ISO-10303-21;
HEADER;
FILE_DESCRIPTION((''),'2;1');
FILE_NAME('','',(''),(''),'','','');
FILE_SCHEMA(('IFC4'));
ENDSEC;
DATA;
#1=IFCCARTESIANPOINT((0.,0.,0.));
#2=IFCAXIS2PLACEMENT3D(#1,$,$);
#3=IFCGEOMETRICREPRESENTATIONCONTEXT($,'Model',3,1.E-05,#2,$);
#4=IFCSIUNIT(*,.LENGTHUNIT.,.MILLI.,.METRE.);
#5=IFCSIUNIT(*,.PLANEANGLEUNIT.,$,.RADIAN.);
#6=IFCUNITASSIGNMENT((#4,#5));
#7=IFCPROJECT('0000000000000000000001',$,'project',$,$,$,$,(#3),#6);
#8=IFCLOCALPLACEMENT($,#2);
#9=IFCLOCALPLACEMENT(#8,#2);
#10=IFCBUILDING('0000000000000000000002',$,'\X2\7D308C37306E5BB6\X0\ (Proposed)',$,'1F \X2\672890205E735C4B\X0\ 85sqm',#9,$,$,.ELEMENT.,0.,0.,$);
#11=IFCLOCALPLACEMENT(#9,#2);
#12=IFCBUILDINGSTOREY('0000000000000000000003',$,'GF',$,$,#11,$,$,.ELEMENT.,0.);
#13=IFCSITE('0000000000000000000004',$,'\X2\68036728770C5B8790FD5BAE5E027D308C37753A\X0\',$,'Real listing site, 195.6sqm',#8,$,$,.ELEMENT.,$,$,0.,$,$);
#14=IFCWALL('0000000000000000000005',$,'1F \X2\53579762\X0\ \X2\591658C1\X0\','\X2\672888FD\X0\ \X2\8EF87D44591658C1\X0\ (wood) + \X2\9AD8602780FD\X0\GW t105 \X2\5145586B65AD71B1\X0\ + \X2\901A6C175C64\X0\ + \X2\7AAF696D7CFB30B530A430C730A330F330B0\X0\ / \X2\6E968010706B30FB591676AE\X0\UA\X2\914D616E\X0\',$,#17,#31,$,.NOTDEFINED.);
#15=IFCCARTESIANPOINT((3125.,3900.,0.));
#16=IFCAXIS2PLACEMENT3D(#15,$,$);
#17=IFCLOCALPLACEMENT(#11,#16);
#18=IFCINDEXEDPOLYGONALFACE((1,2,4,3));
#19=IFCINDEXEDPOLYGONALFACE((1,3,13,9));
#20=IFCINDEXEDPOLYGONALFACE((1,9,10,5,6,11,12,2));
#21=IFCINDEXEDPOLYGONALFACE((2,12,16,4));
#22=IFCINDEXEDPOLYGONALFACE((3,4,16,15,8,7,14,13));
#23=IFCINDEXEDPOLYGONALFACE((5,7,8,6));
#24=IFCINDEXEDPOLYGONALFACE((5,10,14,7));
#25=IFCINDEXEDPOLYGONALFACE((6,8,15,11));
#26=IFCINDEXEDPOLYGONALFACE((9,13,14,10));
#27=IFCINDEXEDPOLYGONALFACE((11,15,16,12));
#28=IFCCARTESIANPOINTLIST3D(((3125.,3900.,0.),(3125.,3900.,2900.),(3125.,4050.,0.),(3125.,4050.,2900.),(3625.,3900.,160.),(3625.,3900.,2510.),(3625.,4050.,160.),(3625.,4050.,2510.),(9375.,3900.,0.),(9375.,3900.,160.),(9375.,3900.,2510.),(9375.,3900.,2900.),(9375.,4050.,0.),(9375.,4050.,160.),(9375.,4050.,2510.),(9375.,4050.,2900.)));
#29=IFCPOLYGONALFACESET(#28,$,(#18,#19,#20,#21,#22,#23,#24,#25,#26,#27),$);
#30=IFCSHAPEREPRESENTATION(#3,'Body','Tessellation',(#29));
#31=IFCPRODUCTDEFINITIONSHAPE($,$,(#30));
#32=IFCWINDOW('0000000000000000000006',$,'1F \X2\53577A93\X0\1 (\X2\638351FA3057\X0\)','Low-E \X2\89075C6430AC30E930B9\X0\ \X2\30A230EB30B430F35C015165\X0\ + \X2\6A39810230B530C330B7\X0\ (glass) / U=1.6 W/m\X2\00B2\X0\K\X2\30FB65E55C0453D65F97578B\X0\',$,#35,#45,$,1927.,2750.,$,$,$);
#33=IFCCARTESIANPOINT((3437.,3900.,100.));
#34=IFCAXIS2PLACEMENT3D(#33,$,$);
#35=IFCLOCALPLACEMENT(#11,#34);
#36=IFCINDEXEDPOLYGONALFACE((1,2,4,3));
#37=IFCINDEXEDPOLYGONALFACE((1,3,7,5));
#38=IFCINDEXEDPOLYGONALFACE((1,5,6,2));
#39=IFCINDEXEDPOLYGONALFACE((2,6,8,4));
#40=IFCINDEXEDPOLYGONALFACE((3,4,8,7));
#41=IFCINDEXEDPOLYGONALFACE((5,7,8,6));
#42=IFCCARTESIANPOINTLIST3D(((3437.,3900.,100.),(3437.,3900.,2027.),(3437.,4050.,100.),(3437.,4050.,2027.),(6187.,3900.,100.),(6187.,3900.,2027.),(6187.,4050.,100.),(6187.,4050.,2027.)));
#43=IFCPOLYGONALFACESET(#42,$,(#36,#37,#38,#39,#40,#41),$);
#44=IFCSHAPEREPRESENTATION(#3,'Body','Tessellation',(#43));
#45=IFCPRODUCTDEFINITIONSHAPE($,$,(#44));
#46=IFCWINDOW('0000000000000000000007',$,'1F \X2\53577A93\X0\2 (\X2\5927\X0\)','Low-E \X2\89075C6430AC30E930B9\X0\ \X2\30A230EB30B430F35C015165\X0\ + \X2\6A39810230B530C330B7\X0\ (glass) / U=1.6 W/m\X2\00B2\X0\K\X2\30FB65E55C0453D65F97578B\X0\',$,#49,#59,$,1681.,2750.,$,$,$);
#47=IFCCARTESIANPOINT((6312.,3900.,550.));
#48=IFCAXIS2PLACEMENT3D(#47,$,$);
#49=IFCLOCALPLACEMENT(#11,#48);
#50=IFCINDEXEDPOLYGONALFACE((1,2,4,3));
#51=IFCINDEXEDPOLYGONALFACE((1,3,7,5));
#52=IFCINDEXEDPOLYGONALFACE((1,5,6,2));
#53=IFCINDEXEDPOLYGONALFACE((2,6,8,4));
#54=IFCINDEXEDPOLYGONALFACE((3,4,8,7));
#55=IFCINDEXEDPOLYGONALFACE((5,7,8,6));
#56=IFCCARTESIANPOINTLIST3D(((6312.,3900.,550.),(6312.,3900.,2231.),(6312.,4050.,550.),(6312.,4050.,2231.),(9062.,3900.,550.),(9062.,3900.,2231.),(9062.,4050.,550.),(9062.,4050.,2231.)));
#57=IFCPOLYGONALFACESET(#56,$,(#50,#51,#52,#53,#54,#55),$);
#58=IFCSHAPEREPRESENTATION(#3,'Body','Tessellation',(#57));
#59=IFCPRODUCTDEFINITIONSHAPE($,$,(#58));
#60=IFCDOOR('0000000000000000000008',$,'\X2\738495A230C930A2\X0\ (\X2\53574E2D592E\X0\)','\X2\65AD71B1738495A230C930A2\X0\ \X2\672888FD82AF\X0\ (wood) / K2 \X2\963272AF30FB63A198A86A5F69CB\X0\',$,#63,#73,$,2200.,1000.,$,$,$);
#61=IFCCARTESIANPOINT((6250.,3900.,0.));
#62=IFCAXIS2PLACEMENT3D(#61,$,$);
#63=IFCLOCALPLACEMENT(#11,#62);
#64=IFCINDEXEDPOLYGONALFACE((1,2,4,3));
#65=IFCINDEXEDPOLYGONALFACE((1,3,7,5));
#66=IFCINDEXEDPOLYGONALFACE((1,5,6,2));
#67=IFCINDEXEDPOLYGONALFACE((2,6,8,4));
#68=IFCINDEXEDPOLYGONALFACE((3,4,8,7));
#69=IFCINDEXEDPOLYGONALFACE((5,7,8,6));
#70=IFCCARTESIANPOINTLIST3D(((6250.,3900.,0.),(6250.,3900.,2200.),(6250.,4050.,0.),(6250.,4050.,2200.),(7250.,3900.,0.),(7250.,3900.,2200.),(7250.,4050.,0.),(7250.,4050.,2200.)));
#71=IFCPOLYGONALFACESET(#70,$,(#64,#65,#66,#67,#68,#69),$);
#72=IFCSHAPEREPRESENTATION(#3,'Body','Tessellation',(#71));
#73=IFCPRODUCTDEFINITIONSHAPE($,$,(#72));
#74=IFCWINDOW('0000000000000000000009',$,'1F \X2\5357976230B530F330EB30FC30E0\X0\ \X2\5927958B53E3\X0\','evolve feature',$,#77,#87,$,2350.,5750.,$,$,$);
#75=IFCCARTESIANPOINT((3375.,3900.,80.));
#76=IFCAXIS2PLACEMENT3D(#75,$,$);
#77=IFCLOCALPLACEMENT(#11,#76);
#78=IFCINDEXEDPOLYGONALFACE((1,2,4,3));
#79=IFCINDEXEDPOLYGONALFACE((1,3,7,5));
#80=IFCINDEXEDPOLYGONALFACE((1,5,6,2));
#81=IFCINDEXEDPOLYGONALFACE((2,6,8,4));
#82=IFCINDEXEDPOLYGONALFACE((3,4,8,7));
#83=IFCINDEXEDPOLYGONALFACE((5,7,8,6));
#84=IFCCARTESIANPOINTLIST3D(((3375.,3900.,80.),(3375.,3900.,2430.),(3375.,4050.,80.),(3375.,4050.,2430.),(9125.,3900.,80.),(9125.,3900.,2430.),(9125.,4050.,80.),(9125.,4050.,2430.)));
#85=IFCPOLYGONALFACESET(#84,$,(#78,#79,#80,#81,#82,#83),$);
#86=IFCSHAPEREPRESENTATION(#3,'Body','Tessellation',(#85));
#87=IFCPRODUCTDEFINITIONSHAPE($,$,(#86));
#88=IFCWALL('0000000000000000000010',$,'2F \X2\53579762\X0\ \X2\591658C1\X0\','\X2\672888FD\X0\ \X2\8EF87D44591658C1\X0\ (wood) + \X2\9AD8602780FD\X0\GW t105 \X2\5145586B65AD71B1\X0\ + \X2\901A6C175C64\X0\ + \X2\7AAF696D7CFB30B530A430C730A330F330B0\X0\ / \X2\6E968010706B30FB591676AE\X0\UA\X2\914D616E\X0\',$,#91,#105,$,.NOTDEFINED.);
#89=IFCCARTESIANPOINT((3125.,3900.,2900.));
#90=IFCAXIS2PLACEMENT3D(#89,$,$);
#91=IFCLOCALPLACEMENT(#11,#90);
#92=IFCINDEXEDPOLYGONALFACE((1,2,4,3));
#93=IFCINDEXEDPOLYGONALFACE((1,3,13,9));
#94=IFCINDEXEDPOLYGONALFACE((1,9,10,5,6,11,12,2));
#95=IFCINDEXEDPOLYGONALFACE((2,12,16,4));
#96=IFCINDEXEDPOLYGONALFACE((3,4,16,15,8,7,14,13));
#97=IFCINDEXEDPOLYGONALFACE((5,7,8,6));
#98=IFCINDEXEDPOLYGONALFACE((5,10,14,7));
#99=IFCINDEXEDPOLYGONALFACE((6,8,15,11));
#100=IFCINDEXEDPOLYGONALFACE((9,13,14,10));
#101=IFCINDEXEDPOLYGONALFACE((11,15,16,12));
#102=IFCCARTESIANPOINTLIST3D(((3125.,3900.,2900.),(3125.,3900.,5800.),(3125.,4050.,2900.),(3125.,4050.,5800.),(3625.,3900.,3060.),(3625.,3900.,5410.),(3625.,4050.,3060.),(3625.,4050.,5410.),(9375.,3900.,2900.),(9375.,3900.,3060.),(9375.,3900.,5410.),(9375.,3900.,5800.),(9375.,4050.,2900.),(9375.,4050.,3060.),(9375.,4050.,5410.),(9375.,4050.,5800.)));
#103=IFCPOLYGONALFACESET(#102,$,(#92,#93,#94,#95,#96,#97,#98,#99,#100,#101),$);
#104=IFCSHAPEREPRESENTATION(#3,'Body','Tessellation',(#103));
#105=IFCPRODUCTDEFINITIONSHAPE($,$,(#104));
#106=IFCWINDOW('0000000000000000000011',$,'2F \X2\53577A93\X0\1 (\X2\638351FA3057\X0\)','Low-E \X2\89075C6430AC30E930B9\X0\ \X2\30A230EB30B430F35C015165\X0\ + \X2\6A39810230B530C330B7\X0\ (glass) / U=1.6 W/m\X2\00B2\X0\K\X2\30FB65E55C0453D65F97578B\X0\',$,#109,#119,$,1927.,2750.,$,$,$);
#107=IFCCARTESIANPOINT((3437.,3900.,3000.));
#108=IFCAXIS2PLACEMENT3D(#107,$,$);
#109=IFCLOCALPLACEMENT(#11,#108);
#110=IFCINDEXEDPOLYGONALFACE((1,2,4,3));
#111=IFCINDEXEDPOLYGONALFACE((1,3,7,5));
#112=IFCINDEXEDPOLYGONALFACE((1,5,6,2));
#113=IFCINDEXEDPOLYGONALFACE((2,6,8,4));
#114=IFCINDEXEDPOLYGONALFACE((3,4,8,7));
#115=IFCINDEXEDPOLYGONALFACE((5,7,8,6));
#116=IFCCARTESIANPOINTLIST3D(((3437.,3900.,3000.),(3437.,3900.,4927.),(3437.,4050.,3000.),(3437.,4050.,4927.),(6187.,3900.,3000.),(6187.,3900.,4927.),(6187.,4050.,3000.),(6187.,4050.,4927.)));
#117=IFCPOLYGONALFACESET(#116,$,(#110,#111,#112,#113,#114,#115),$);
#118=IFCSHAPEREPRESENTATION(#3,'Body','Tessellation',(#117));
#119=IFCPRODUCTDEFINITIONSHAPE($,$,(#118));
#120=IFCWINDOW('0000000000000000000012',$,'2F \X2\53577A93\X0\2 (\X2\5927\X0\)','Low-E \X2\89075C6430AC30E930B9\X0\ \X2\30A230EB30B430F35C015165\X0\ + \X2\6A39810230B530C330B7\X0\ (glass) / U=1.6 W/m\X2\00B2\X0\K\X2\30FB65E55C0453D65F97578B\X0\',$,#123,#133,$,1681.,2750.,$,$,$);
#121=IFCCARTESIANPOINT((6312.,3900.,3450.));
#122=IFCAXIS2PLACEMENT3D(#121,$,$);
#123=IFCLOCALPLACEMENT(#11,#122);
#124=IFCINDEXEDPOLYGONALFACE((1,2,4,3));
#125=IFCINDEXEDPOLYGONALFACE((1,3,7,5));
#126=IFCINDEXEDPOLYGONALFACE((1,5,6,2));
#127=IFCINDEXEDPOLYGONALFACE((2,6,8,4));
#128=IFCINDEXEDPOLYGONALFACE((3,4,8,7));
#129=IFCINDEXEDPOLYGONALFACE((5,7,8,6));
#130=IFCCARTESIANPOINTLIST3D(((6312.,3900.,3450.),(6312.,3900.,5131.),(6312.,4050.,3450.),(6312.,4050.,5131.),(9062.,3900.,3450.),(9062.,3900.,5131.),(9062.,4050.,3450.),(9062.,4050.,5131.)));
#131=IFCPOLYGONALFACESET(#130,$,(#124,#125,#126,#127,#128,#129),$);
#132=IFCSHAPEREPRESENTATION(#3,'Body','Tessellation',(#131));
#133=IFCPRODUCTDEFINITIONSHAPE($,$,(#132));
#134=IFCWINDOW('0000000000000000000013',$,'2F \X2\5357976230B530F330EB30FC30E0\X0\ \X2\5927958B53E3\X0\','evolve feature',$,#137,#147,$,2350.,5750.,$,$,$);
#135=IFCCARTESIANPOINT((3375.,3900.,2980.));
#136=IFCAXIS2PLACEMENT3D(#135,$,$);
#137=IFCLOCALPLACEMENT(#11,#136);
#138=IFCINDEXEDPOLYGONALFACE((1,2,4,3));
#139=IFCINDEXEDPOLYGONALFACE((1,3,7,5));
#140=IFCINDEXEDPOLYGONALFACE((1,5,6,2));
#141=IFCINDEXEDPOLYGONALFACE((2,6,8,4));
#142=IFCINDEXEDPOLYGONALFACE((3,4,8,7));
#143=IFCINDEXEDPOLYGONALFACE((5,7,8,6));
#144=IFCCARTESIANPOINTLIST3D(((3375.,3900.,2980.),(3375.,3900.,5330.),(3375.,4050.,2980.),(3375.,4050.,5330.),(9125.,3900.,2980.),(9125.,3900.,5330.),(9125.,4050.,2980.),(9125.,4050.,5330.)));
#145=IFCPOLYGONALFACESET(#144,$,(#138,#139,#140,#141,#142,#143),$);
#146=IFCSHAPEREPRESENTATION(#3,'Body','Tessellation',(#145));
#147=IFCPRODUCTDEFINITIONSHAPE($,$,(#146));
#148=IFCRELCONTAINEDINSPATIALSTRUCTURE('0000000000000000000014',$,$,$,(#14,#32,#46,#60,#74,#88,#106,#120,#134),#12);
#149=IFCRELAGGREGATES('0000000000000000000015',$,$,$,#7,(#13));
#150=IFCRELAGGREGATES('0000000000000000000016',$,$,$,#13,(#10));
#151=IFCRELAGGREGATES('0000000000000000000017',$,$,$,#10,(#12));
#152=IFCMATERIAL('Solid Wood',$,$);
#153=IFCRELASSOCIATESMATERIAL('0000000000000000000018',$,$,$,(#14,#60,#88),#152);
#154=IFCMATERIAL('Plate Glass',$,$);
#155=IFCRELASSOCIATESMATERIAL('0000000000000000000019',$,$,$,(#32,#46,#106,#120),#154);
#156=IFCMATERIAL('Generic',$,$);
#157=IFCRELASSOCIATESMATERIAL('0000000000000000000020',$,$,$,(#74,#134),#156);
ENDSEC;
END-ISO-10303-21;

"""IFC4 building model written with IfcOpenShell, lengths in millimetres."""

from ifc_helpers import new_model, si_unit, frame, frame_2d, origin, place, context, project, spatial, rectangle, extrude, material, element, fill, save


model = new_model("IFC4")

# Units and contexts
model_context = context("Model", 3, precision=1e-05, world=origin())
ifc_project = project(units=[si_unit("LENGTHUNIT", "METRE", prefix="MILLI"), si_unit("PLANEANGLEUNIT", "RADIAN")], contexts=[model_context])

# Site, building, storey
site_placement = place(None, origin())
site = spatial("IfcSite", under=ifc_project, at=site_placement, Name="栃木県宇都宮市細谷町", ObjectType="Real listing site, 195.6sqm", CompositionType="ELEMENT", RefElevation=0.0)
building_placement = place(site_placement, origin())
building = spatial("IfcBuilding", under=site, at=building_placement, Name="細谷の家 (Proposed)", ObjectType="1F 木造平屋 85sqm", CompositionType="ELEMENT", ElevationOfRefHeight=0.0, ElevationOfTerrain=0.0)
storey_placement = place(building_placement, origin())
storey = spatial("IfcBuildingStorey", under=building, at=storey_placement, Name="GF", CompositionType="ELEMENT", Elevation=0.0)

# Shared definitions
ifc_material_1 = material(Name="Solid Wood")
ifc_material_2 = material(Name="Generic")

# Wall, openings, windows, door
wall_1_placement = place(storey_placement, frame((3125.0, 3900.0, 0.0)))
wall_1 = element("IfcWall", 1, at=wall_1_placement, inside=storey, material=ifc_material_1, Name="1F 南面 外壁", Description="木製 軸組外壁 (wood) + 高性能GW t105 充填断熱 + 通気層 + 窯業系サイディング / 準耐火・外皮UA配慮", PredefinedType="NOTDEFINED", context=model_context, shape_type="SweptSolid", body=[
    extrude(rectangle(XDim=6250.0, YDim=150.0, at=frame_2d((3125.0, 75.0))), frame((3125.0, 3900.0, 0.0)), (0.0, 0.0, 1.0), 2900.0),
])
opening_1_placement = place(storey_placement, frame((3437.0, 3900.0, 100.0)))
opening_1 = element("IfcOpeningElement", 2, at=opening_1_placement, cuts=wall_1, PredefinedType="NOTDEFINED", context=model_context, shape_type="SweptSolid", body=[
    extrude(rectangle(XDim=2750.0, YDim=150.0, at=frame_2d((1375.0, 75.0))), frame((3437.0, 3900.0, 100.0)), (0.0, 0.0, 1.0), 1927.0),
])
opening_2_placement = place(storey_placement, frame((6312.0, 3900.0, 550.0)))
opening_2 = element("IfcOpeningElement", 3, at=opening_2_placement, cuts=wall_1, PredefinedType="NOTDEFINED", context=model_context, shape_type="SweptSolid", body=[
    extrude(rectangle(XDim=2750.0, YDim=150.0, at=frame_2d((1375.0, 75.0))), frame((6312.0, 3900.0, 550.0)), (0.0, 0.0, 1.0), 1681.0),
])
opening_3_placement = place(storey_placement, frame((6250.0, 3900.0, 0.0)))
opening_3 = element("IfcOpeningElement", 4, at=opening_3_placement, cuts=wall_1, PredefinedType="NOTDEFINED", context=model_context, shape_type="SweptSolid", body=[
    extrude(rectangle(XDim=1000.0, YDim=150.0, at=frame_2d((500.0, 75.0))), frame((6250.0, 3900.0, 0.0)), (0.0, 0.0, 1.0), 2200.0),
])
opening_4_placement = place(storey_placement, frame((3375.0, 3900.0, 80.0)))
opening_4 = element("IfcOpeningElement", 5, at=opening_4_placement, cuts=wall_1, PredefinedType="NOTDEFINED", context=model_context, shape_type="SweptSolid", body=[
    extrude(rectangle(XDim=5750.0, YDim=150.0, at=frame_2d((2875.0, 75.0))), frame((3375.0, 3900.0, 80.0)), (0.0, 0.0, 1.0), 2350.0),
])
ifc_material_3 = material(Name="Plate Glass")
window_1_placement = place(storey_placement, frame((3437.0, 3900.0, 100.0)))
window_1 = element("IfcWindow", 6, at=window_1_placement, inside=storey, material=ifc_material_3, Name="1F 南窓1 (掃出し)", Description="Low-E 複層ガラス アルゴン封入 + 樹脂サッシ (glass) / U=1.6 W/m²K・日射取得型", OverallHeight=1927.0, OverallWidth=2750.0, context=model_context, shape_type="SweptSolid", body=[
    extrude(rectangle(XDim=2750.0, YDim=150.0, at=frame_2d((1375.0, 75.0))), frame((3437.0, 3900.0, 100.0)), (0.0, 0.0, 1.0), 1927.0),
])
fill(opening_1, window_1)
window_2_placement = place(storey_placement, frame((6312.0, 3900.0, 550.0)))
window_2 = element("IfcWindow", 7, at=window_2_placement, inside=storey, material=ifc_material_3, Name="1F 南窓2 (大)", Description="Low-E 複層ガラス アルゴン封入 + 樹脂サッシ (glass) / U=1.6 W/m²K・日射取得型", OverallHeight=1681.0, OverallWidth=2750.0, context=model_context, shape_type="SweptSolid", body=[
    extrude(rectangle(XDim=2750.0, YDim=150.0, at=frame_2d((1375.0, 75.0))), frame((6312.0, 3900.0, 550.0)), (0.0, 0.0, 1.0), 1681.0),
])
fill(opening_2, window_2)
door_placement = place(storey_placement, frame((6250.0, 3900.0, 0.0)))
door = element("IfcDoor", 8, at=door_placement, inside=storey, material=ifc_material_1, Name="玄関ドア (南中央)", Description="断熱玄関ドア 木製芯 (wood) / K2 防犯・採風機構", OverallHeight=2200.0, OverallWidth=1000.0, context=model_context, shape_type="SweptSolid", body=[
    extrude(rectangle(XDim=1000.0, YDim=150.0, at=frame_2d((500.0, 75.0))), frame((6250.0, 3900.0, 0.0)), (0.0, 0.0, 1.0), 2200.0),
])
fill(opening_3, door)
window_3_placement = place(storey_placement, frame((3375.0, 3900.0, 80.0)))
window_3 = element("IfcWindow", 9, at=window_3_placement, inside=storey, material=ifc_material_2, Name="1F 南面サンルーム 大開口", Description="evolve feature", OverallHeight=2350.0, OverallWidth=5750.0, context=model_context, shape_type="SweptSolid", body=[
    extrude(rectangle(XDim=5750.0, YDim=150.0, at=frame_2d((2875.0, 75.0))), frame((3375.0, 3900.0, 80.0)), (0.0, 0.0, 1.0), 2350.0),
])
fill(opening_4, window_3)

# Wall, openings, windows
wall_2_placement = place(storey_placement, frame((3125.0, 3900.0, 2900.0)))
wall_2 = element("IfcWall", 10, at=wall_2_placement, inside=storey, material=ifc_material_1, Name="2F 南面 外壁", Description="木製 軸組外壁 (wood) + 高性能GW t105 充填断熱 + 通気層 + 窯業系サイディング / 準耐火・外皮UA配慮", PredefinedType="NOTDEFINED", context=model_context, shape_type="SweptSolid", body=[
    extrude(rectangle(XDim=6250.0, YDim=150.0, at=frame_2d((3125.0, 75.0))), frame((3125.0, 3900.0, 2900.0)), (0.0, 0.0, 1.0), 2900.0),
])
opening_5_placement = place(storey_placement, frame((3437.0, 3900.0, 3000.0)))
opening_5 = element("IfcOpeningElement", 11, at=opening_5_placement, cuts=wall_2, PredefinedType="NOTDEFINED", context=model_context, shape_type="SweptSolid", body=[
    extrude(rectangle(XDim=2750.0, YDim=150.0, at=frame_2d((1375.0, 75.0))), frame((3437.0, 3900.0, 3000.0)), (0.0, 0.0, 1.0), 1927.0),
])
opening_6_placement = place(storey_placement, frame((6312.0, 3900.0, 3450.0)))
opening_6 = element("IfcOpeningElement", 12, at=opening_6_placement, cuts=wall_2, PredefinedType="NOTDEFINED", context=model_context, shape_type="SweptSolid", body=[
    extrude(rectangle(XDim=2750.0, YDim=150.0, at=frame_2d((1375.0, 75.0))), frame((6312.0, 3900.0, 3450.0)), (0.0, 0.0, 1.0), 1681.0),
])
opening_7_placement = place(storey_placement, frame((3375.0, 3900.0, 2980.0)))
opening_7 = element("IfcOpeningElement", 13, at=opening_7_placement, cuts=wall_2, PredefinedType="NOTDEFINED", context=model_context, shape_type="SweptSolid", body=[
    extrude(rectangle(XDim=5750.0, YDim=150.0, at=frame_2d((2875.0, 75.0))), frame((3375.0, 3900.0, 2980.0)), (0.0, 0.0, 1.0), 2350.0),
])
window_4_placement = place(storey_placement, frame((3437.0, 3900.0, 3000.0)))
window_4 = element("IfcWindow", 14, at=window_4_placement, inside=storey, material=ifc_material_3, Name="2F 南窓1 (掃出し)", Description="Low-E 複層ガラス アルゴン封入 + 樹脂サッシ (glass) / U=1.6 W/m²K・日射取得型", OverallHeight=1927.0, OverallWidth=2750.0, context=model_context, shape_type="SweptSolid", body=[
    extrude(rectangle(XDim=2750.0, YDim=150.0, at=frame_2d((1375.0, 75.0))), frame((3437.0, 3900.0, 3000.0)), (0.0, 0.0, 1.0), 1927.0),
])
fill(opening_5, window_4)
window_5_placement = place(storey_placement, frame((6312.0, 3900.0, 3450.0)))
window_5 = element("IfcWindow", 15, at=window_5_placement, inside=storey, material=ifc_material_3, Name="2F 南窓2 (大)", Description="Low-E 複層ガラス アルゴン封入 + 樹脂サッシ (glass) / U=1.6 W/m²K・日射取得型", OverallHeight=1681.0, OverallWidth=2750.0, context=model_context, shape_type="SweptSolid", body=[
    extrude(rectangle(XDim=2750.0, YDim=150.0, at=frame_2d((1375.0, 75.0))), frame((6312.0, 3900.0, 3450.0)), (0.0, 0.0, 1.0), 1681.0),
])
fill(opening_6, window_5)
window_6_placement = place(storey_placement, frame((3375.0, 3900.0, 2980.0)))
window_6 = element("IfcWindow", 16, at=window_6_placement, inside=storey, material=ifc_material_2, Name="2F 南面サンルーム 大開口", Description="evolve feature", OverallHeight=2350.0, OverallWidth=5750.0, context=model_context, shape_type="SweptSolid", body=[
    extrude(rectangle(XDim=5750.0, YDim=150.0, at=frame_2d((2875.0, 75.0))), frame((3375.0, 3900.0, 2980.0)), (0.0, 0.0, 1.0), 2350.0),
])
fill(opening_7, window_6)

save(model, "model.ifc")
